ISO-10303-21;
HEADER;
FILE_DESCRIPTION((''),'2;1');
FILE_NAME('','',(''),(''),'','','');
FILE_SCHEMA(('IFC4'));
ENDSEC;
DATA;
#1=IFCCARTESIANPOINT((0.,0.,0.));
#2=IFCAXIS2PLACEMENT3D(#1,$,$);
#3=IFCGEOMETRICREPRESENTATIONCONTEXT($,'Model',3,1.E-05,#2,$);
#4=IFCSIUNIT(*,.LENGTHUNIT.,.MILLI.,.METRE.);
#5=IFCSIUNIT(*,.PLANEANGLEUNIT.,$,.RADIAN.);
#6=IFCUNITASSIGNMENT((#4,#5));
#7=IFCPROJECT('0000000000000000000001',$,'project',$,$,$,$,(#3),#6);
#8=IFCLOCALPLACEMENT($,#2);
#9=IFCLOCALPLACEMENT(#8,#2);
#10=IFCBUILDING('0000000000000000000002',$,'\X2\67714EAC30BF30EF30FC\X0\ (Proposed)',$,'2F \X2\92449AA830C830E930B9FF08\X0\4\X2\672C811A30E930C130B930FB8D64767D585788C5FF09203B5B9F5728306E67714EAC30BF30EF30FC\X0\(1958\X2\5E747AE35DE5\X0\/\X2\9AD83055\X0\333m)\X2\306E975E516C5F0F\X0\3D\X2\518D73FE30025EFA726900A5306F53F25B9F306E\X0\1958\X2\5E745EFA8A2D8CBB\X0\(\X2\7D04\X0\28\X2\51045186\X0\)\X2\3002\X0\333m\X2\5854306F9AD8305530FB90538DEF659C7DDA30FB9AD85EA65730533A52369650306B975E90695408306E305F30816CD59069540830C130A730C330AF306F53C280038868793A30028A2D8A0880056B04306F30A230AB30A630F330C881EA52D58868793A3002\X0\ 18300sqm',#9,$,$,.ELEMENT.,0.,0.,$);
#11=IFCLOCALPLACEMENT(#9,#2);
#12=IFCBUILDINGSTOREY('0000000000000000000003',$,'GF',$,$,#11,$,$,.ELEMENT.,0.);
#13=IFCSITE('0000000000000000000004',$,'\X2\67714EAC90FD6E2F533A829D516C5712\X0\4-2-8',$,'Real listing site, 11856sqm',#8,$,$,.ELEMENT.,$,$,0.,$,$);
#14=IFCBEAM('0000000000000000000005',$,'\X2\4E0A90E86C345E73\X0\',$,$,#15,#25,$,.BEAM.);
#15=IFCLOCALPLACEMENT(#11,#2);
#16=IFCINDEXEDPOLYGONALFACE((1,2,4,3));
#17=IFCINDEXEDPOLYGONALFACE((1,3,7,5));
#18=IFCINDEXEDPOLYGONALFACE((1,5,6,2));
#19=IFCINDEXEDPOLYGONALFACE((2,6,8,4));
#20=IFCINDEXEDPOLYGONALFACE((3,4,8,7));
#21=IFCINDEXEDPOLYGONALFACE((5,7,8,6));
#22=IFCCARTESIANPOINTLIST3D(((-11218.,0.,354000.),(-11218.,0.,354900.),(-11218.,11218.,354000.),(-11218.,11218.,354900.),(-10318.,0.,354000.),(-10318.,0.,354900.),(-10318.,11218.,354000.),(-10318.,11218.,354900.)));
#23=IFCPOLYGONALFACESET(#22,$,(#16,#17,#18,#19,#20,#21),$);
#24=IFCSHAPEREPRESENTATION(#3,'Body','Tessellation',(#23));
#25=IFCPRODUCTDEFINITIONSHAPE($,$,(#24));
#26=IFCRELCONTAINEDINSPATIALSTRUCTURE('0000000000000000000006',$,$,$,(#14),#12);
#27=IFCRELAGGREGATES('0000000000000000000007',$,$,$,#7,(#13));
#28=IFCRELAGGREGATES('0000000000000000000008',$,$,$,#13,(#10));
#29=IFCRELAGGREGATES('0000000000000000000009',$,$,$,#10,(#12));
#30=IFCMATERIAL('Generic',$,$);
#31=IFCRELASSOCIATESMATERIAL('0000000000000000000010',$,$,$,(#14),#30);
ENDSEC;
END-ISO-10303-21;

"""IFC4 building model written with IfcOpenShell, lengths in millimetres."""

from ifc_helpers import new_model, si_unit, frame, frame_2d, origin, place, context, project, spatial, rectangle, extrude, material, element, save


model = new_model("IFC4")

# Units and contexts
model_context = context("Model", 3, precision=1e-05, world=origin())
ifc_project = project(units=[si_unit("LENGTHUNIT", "METRE", prefix="MILLI"), si_unit("PLANEANGLEUNIT", "RADIAN")], contexts=[model_context])

# Site, building, storey
site_placement = place(None, origin())
site = spatial("IfcSite", under=ifc_project, at=site_placement, Name="東京都港区芝公園4-2-8", ObjectType="Real listing site, 11856sqm", CompositionType="ELEMENT", RefElevation=0.0)
building_placement = place(site_placement, origin())
building = spatial("IfcBuilding", under=site, at=building_placement, Name="東京タワー (Proposed)", ObjectType="2F 鉄骨トラス（4本脚ラチス・赤白塗装）※実在の東京タワー(1958年竣工/高さ333m)の非公式3D再現。建物¥は史実の1958年建設費(約28億円)。333m塔は高さ・道路斜線・高度地区制限に非適合のため法適合チェックは参考表示。設計者欄はアカウント自動表示。 18300sqm", CompositionType="ELEMENT", ElevationOfRefHeight=0.0, ElevationOfTerrain=0.0)
storey_placement = place(building_placement, origin())
storey = spatial("IfcBuildingStorey", under=building, at=storey_placement, Name="GF", CompositionType="ELEMENT", Elevation=0.0)

# Shared definitions
ifc_material = material(Name="Generic")

# Beam
beam_placement = place(storey_placement, frame((-5609.0, 0.0, 177000.0)))
element("IfcBeam", 1, at=beam_placement, inside=storey, material=ifc_material, Name="上部水平", PredefinedType="BEAM", context=model_context, shape_type="SweptSolid", body=[
    extrude(rectangle(XDim=900.0, YDim=11218.0, at=frame_2d((450.0, 5609.0))), frame((-5609.0, 0.0, 177000.0)), (0.0, 0.0, 1.0), 900.0),
])

save(model, "model.ifc")
